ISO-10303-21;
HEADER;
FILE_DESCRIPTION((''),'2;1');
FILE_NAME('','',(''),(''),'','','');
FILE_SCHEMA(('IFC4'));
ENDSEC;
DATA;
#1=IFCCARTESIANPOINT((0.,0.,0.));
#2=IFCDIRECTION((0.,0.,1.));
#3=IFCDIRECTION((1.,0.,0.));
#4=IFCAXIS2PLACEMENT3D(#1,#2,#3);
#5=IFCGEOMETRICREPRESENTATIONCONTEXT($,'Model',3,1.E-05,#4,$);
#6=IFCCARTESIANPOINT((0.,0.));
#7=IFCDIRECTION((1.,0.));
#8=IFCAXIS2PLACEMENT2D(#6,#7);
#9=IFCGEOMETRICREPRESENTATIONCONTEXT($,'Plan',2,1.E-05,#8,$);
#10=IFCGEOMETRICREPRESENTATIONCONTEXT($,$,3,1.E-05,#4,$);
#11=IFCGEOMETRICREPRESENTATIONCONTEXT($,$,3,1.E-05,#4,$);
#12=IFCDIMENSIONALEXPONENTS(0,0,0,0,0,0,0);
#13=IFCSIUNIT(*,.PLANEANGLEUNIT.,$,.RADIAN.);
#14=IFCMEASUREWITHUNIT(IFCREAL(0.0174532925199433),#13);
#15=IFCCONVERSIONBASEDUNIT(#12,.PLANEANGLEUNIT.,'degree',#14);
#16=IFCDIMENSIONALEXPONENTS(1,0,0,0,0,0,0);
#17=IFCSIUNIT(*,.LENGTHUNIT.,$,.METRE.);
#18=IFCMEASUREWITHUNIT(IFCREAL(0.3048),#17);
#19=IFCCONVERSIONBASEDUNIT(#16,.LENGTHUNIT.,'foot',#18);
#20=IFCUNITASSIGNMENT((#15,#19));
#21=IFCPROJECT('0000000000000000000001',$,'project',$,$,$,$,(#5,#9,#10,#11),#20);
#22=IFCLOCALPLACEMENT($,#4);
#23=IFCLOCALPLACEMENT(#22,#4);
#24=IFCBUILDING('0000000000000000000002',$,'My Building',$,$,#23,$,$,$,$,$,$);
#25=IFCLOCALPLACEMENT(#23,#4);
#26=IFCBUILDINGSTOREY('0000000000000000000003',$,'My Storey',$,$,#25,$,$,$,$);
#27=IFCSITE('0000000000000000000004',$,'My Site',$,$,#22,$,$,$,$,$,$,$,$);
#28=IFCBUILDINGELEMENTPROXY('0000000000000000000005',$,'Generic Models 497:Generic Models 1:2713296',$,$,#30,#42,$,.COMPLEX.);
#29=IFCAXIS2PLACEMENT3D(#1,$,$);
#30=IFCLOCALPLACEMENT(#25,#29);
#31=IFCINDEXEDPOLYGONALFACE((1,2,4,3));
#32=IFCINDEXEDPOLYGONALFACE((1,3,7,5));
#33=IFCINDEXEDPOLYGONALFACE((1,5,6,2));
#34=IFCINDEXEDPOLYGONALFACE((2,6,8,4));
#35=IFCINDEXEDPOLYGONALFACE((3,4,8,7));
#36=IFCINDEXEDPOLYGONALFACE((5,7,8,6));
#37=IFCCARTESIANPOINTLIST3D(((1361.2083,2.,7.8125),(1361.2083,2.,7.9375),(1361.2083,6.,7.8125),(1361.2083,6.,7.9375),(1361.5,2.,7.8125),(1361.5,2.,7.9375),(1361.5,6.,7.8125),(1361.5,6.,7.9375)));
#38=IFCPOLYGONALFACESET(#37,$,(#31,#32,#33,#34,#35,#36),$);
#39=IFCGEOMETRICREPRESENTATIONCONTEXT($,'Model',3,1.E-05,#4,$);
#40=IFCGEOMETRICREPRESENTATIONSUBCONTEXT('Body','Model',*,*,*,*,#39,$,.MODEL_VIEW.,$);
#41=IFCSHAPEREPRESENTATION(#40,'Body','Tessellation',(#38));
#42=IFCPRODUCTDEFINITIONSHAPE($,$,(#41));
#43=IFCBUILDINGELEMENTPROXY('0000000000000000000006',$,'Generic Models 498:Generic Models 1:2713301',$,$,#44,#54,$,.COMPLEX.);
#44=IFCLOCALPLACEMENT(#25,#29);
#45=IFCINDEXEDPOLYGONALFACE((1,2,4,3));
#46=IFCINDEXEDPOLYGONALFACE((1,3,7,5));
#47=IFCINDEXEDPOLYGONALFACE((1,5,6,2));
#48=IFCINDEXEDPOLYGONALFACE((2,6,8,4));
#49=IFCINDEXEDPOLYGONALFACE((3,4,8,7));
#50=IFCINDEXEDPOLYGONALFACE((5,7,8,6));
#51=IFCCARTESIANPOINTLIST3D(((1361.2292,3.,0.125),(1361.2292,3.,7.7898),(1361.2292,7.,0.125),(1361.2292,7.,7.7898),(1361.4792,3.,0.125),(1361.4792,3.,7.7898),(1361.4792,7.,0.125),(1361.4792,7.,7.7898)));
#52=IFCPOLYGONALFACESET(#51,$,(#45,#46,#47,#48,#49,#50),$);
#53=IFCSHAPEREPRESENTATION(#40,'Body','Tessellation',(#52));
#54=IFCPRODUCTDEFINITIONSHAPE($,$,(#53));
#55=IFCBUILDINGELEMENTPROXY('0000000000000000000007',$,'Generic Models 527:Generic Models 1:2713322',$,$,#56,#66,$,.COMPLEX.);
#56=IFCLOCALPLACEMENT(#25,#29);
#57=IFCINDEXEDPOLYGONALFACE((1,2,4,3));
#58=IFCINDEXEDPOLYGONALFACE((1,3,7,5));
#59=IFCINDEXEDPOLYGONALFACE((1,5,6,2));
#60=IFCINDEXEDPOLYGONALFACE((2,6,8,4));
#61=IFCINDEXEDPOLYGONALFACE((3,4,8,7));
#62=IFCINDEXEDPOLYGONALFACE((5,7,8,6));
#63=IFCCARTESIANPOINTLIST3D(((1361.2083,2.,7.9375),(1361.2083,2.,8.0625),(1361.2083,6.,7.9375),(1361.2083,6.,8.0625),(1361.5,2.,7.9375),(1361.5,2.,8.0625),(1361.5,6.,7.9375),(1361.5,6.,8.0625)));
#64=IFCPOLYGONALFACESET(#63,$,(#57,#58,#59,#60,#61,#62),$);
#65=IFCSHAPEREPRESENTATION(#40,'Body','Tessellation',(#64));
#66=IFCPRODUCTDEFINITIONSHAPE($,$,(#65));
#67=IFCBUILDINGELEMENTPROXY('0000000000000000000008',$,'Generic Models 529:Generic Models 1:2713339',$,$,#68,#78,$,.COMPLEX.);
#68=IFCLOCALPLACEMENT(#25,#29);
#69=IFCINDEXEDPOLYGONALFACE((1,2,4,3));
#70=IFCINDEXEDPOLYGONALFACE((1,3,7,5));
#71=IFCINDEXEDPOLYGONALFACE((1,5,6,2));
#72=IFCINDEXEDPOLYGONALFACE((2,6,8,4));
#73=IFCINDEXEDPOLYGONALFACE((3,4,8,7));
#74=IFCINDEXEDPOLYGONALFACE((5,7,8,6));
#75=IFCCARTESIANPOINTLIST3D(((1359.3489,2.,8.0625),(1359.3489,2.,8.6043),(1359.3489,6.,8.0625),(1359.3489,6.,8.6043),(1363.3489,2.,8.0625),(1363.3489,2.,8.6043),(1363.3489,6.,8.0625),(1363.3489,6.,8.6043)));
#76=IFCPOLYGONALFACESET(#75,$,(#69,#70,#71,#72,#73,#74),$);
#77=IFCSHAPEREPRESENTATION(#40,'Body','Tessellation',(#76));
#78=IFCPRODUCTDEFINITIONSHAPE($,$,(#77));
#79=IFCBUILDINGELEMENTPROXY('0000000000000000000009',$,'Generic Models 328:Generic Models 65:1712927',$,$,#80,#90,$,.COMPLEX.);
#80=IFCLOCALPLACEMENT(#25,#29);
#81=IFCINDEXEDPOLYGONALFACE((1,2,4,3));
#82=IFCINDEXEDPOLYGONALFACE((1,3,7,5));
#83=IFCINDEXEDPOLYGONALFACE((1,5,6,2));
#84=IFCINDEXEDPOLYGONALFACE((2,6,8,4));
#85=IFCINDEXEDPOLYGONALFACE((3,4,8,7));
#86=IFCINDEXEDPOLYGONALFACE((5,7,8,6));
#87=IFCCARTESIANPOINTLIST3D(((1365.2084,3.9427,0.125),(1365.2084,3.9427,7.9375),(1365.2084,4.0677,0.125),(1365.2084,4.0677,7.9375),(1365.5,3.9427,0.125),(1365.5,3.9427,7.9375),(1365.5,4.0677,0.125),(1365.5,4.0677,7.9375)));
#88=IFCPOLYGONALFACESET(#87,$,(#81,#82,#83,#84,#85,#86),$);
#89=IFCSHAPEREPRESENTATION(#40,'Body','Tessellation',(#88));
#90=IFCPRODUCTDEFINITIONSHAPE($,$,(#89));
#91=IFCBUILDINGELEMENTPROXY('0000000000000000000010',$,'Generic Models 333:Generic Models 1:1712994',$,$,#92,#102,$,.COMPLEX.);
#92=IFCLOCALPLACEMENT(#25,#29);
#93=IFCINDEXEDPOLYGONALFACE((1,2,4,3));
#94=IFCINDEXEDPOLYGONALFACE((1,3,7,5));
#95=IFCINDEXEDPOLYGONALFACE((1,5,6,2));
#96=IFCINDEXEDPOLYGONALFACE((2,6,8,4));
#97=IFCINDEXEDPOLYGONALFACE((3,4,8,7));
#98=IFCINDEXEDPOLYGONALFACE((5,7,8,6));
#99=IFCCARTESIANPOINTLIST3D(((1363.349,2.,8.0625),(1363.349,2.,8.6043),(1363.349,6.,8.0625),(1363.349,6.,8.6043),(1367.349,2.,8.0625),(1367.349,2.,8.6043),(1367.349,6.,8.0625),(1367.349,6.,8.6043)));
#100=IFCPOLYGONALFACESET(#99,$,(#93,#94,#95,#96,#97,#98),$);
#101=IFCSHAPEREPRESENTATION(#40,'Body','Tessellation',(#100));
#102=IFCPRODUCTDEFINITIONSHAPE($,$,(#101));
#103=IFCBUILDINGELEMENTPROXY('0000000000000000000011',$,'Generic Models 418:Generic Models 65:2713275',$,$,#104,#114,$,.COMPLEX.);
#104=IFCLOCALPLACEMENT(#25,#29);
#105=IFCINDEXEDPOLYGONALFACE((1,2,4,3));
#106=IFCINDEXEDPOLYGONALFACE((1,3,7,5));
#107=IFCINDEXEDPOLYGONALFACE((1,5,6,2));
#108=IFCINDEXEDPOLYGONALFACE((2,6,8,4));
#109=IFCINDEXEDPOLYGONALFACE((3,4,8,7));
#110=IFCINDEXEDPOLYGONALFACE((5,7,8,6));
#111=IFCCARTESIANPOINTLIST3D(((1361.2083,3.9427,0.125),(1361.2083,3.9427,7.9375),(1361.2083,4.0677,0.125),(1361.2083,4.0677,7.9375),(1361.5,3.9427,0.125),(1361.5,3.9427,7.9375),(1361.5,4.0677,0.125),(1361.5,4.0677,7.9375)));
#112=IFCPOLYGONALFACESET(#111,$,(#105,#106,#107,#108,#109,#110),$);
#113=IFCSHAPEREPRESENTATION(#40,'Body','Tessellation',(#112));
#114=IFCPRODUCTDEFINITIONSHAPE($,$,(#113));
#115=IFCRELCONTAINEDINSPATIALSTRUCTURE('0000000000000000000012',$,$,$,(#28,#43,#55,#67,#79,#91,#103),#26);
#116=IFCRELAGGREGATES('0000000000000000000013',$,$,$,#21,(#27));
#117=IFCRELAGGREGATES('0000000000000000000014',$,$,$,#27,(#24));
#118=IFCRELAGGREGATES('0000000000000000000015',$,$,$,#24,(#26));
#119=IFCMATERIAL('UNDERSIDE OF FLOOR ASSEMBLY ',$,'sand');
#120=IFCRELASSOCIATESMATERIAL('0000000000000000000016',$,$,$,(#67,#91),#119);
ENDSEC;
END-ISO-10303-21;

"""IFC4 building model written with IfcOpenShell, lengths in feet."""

from ifc_helpers import new_model, entity, si_unit, converted_unit, frame, origin_with_axes, origin_2d_with_axis, place, context, subcontext, project, spatial, polyline, outline, extrude, material, element, save


model = new_model("IFC4")

# Units and contexts
model_context_1 = context("Model", 3, precision=1e-05, world=origin_with_axes())
plan_context = context("Plan", 2, precision=1e-05, world=origin_2d_with_axis())
model_context_2 = context("Model", 3, precision=1e-05, world=origin_with_axes())
context_of_model_1 = context(None, 3, precision=1e-05, world=origin_with_axes())
context_of_model_2 = context(None, 3, precision=1e-05, world=origin_with_axes())
body_context = subcontext(model_context_2, "Body", "Model", "MODEL_VIEW")
ifc_project = project(units=[converted_unit("PLANEANGLEUNIT", "degree", entity("IfcReal", 0.0174532925199433), si_unit("PLANEANGLEUNIT", "RADIAN"), dimensions=[0, 0, 0, 0, 0, 0, 0]), converted_unit("LENGTHUNIT", "foot", entity("IfcReal", 0.3048), si_unit("LENGTHUNIT", "METRE"), dimensions=[1, 0, 0, 0, 0, 0, 0])], contexts=[model_context_1, plan_context, context_of_model_1, context_of_model_2])

# Site, building, storey
site_placement = place(None, origin_with_axes())
site = spatial("IfcSite", under=ifc_project, at=site_placement, Name="My Site")
building_placement = place(site_placement, origin_with_axes())
building = spatial("IfcBuilding", under=site, at=building_placement, Name="My Building")
storey_placement = place(building_placement, origin_with_axes())
storey = spatial("IfcBuildingStorey", under=building, at=storey_placement, Name="My Storey")

# Building element proxies
proxy_1_placement = place(storey_placement, frame((1361.2083, 6.0, 7.8125), z_axis=(0.0, -1.0, 0.0), x_axis=(0.0, 0.0, 1.0)))
element("IfcBuildingElementProxy", 1, at=proxy_1_placement, inside=storey, Name="Generic Models 497:Generic Models 1:2713296", PredefinedType="COMPLEX", context=body_context, shape_type="SweptSolid", body=[
    extrude(outline(polyline([(-0.1458, -0.0625), (0.1458, -0.0625), (0.1458, 0.0625), (-0.1458, 0.0625), (-0.1458, -0.0625)])), frame((0.0625, -0.1458, 0.0), z_axis=(0.0, 0.0, -1.0), x_axis=(0.0, 1.0, 0.0)), (0.0, 0.0, -1.0), 4.0),
])
proxy_2_placement = place(storey_placement, frame((1361.2292, 3.0, 0.125), z_axis=(0.0, 0.0, 1.0), x_axis=(0.0, 1.0, 0.0)))
element("IfcBuildingElementProxy", 2, at=proxy_2_placement, inside=storey, Name="Generic Models 498:Generic Models 1:2713301", PredefinedType="COMPLEX", context=body_context, shape_type="SweptSolid", body=[
    extrude(outline(polyline([(-2.0, -0.125), (2.0, -0.125), (2.0, 0.125), (-2.0, 0.125), (-2.0, -0.125)])), frame((2.0, -0.125, 0.0), z_axis=(0.0, 0.0, -1.0), x_axis=(-1.0, 0.0, 0.0)), (0.0, 0.0, -1.0), 7.6648),
])
proxy_3_placement = place(storey_placement, frame((1361.2083, 6.0, 7.9375), z_axis=(0.0, -1.0, 0.0), x_axis=(0.0, 0.0, 1.0)))
element("IfcBuildingElementProxy", 3, at=proxy_3_placement, inside=storey, Name="Generic Models 527:Generic Models 1:2713322", PredefinedType="COMPLEX", context=body_context, shape_type="SweptSolid", body=[
    extrude(outline(polyline([(-0.1458, -0.0625), (0.1458, -0.0625), (0.1458, 0.0625), (-0.1458, 0.0625), (-0.1458, -0.0625)])), frame((0.0625, -0.1458, 0.0), z_axis=(0.0, 0.0, -1.0), x_axis=(0.0, 1.0, 0.0)), (0.0, 0.0, -1.0), 4.0),
])
ifc_material_1 = material(Name="UNDERSIDE OF FLOOR ASSEMBLY ", Category="sand")
proxy_4_placement = place(storey_placement, frame((1359.3489, 6.0, 8.0625), z_axis=(0.0, -1.0, 0.0), x_axis=(0.0, 0.0, 1.0)))
element("IfcBuildingElementProxy", 4, at=proxy_4_placement, inside=storey, material=ifc_material_1, Name="Generic Models 529:Generic Models 1:2713339", PredefinedType="COMPLEX", context=body_context, shape_type="SweptSolid", body=[
    extrude(outline(polyline([(-0.2709, -2.0), (0.2709, -2.0), (0.2709, 2.0), (-0.2709, 2.0), (-0.2709, -2.0)])), frame((0.2709, -2.0, 0.0), z_axis=(0.0, 0.0, -1.0), x_axis=(1.0, 0.0, 0.0)), (0.0, 0.0, -1.0), 4.0),
])
proxy_5_placement = place(storey_placement, frame((1365.2084, 3.9427, 0.125), z_axis=(0.0, 0.0, 1.0), x_axis=(1.0, 0.0, 0.0)))
element("IfcBuildingElementProxy", 5, at=proxy_5_placement, inside=storey, Name="Generic Models 328:Generic Models 65:1712927", PredefinedType="COMPLEX", context=body_context, shape_type="SweptSolid", body=[
    extrude(outline(polyline([(-0.1458, -0.0625), (0.1458, -0.0625), (0.1458, 0.0625), (-0.1458, 0.0625), (-0.1458, -0.0625)])), frame((0.1458, 0.0625, 0.0), z_axis=(0.0, 0.0, -1.0), x_axis=(-1.0, 0.0, 0.0)), (0.0, 0.0, -1.0), 7.8125),
])
proxy_6_placement = place(storey_placement, frame((1363.349, 6.0, 8.0625), z_axis=(0.0, -1.0, 0.0), x_axis=(0.0, 0.0, 1.0)))
element("IfcBuildingElementProxy", 6, at=proxy_6_placement, inside=storey, material=ifc_material_1, Name="Generic Models 333:Generic Models 1:1712994", PredefinedType="COMPLEX", context=body_context, shape_type="SweptSolid", body=[
    extrude(outline(polyline([(-0.2709, -2.0), (0.2709, -2.0), (0.2709, 2.0), (-0.2709, 2.0), (-0.2709, -2.0)])), frame((0.2709, -2.0, 0.0), z_axis=(0.0, 0.0, -1.0), x_axis=(1.0, 0.0, 0.0)), (0.0, 0.0, -1.0), 4.0),
])
proxy_7_placement = place(storey_placement, frame((1361.2083, 3.9427, 0.125), z_axis=(0.0, 0.0, 1.0), x_axis=(1.0, 0.0, 0.0)))
element("IfcBuildingElementProxy", 7, at=proxy_7_placement, inside=storey, Name="Generic Models 418:Generic Models 65:2713275", PredefinedType="COMPLEX", context=body_context, shape_type="SweptSolid", body=[
    extrude(outline(polyline([(-0.1458, -0.0625), (0.1458, -0.0625), (0.1458, 0.0625), (-0.1458, 0.0625), (-0.1458, -0.0625)])), frame((0.1458, 0.0625, 0.0), z_axis=(0.0, 0.0, -1.0), x_axis=(-1.0, 0.0, 0.0)), (0.0, 0.0, -1.0), 7.8125),
])

save(model, "model.ifc")
